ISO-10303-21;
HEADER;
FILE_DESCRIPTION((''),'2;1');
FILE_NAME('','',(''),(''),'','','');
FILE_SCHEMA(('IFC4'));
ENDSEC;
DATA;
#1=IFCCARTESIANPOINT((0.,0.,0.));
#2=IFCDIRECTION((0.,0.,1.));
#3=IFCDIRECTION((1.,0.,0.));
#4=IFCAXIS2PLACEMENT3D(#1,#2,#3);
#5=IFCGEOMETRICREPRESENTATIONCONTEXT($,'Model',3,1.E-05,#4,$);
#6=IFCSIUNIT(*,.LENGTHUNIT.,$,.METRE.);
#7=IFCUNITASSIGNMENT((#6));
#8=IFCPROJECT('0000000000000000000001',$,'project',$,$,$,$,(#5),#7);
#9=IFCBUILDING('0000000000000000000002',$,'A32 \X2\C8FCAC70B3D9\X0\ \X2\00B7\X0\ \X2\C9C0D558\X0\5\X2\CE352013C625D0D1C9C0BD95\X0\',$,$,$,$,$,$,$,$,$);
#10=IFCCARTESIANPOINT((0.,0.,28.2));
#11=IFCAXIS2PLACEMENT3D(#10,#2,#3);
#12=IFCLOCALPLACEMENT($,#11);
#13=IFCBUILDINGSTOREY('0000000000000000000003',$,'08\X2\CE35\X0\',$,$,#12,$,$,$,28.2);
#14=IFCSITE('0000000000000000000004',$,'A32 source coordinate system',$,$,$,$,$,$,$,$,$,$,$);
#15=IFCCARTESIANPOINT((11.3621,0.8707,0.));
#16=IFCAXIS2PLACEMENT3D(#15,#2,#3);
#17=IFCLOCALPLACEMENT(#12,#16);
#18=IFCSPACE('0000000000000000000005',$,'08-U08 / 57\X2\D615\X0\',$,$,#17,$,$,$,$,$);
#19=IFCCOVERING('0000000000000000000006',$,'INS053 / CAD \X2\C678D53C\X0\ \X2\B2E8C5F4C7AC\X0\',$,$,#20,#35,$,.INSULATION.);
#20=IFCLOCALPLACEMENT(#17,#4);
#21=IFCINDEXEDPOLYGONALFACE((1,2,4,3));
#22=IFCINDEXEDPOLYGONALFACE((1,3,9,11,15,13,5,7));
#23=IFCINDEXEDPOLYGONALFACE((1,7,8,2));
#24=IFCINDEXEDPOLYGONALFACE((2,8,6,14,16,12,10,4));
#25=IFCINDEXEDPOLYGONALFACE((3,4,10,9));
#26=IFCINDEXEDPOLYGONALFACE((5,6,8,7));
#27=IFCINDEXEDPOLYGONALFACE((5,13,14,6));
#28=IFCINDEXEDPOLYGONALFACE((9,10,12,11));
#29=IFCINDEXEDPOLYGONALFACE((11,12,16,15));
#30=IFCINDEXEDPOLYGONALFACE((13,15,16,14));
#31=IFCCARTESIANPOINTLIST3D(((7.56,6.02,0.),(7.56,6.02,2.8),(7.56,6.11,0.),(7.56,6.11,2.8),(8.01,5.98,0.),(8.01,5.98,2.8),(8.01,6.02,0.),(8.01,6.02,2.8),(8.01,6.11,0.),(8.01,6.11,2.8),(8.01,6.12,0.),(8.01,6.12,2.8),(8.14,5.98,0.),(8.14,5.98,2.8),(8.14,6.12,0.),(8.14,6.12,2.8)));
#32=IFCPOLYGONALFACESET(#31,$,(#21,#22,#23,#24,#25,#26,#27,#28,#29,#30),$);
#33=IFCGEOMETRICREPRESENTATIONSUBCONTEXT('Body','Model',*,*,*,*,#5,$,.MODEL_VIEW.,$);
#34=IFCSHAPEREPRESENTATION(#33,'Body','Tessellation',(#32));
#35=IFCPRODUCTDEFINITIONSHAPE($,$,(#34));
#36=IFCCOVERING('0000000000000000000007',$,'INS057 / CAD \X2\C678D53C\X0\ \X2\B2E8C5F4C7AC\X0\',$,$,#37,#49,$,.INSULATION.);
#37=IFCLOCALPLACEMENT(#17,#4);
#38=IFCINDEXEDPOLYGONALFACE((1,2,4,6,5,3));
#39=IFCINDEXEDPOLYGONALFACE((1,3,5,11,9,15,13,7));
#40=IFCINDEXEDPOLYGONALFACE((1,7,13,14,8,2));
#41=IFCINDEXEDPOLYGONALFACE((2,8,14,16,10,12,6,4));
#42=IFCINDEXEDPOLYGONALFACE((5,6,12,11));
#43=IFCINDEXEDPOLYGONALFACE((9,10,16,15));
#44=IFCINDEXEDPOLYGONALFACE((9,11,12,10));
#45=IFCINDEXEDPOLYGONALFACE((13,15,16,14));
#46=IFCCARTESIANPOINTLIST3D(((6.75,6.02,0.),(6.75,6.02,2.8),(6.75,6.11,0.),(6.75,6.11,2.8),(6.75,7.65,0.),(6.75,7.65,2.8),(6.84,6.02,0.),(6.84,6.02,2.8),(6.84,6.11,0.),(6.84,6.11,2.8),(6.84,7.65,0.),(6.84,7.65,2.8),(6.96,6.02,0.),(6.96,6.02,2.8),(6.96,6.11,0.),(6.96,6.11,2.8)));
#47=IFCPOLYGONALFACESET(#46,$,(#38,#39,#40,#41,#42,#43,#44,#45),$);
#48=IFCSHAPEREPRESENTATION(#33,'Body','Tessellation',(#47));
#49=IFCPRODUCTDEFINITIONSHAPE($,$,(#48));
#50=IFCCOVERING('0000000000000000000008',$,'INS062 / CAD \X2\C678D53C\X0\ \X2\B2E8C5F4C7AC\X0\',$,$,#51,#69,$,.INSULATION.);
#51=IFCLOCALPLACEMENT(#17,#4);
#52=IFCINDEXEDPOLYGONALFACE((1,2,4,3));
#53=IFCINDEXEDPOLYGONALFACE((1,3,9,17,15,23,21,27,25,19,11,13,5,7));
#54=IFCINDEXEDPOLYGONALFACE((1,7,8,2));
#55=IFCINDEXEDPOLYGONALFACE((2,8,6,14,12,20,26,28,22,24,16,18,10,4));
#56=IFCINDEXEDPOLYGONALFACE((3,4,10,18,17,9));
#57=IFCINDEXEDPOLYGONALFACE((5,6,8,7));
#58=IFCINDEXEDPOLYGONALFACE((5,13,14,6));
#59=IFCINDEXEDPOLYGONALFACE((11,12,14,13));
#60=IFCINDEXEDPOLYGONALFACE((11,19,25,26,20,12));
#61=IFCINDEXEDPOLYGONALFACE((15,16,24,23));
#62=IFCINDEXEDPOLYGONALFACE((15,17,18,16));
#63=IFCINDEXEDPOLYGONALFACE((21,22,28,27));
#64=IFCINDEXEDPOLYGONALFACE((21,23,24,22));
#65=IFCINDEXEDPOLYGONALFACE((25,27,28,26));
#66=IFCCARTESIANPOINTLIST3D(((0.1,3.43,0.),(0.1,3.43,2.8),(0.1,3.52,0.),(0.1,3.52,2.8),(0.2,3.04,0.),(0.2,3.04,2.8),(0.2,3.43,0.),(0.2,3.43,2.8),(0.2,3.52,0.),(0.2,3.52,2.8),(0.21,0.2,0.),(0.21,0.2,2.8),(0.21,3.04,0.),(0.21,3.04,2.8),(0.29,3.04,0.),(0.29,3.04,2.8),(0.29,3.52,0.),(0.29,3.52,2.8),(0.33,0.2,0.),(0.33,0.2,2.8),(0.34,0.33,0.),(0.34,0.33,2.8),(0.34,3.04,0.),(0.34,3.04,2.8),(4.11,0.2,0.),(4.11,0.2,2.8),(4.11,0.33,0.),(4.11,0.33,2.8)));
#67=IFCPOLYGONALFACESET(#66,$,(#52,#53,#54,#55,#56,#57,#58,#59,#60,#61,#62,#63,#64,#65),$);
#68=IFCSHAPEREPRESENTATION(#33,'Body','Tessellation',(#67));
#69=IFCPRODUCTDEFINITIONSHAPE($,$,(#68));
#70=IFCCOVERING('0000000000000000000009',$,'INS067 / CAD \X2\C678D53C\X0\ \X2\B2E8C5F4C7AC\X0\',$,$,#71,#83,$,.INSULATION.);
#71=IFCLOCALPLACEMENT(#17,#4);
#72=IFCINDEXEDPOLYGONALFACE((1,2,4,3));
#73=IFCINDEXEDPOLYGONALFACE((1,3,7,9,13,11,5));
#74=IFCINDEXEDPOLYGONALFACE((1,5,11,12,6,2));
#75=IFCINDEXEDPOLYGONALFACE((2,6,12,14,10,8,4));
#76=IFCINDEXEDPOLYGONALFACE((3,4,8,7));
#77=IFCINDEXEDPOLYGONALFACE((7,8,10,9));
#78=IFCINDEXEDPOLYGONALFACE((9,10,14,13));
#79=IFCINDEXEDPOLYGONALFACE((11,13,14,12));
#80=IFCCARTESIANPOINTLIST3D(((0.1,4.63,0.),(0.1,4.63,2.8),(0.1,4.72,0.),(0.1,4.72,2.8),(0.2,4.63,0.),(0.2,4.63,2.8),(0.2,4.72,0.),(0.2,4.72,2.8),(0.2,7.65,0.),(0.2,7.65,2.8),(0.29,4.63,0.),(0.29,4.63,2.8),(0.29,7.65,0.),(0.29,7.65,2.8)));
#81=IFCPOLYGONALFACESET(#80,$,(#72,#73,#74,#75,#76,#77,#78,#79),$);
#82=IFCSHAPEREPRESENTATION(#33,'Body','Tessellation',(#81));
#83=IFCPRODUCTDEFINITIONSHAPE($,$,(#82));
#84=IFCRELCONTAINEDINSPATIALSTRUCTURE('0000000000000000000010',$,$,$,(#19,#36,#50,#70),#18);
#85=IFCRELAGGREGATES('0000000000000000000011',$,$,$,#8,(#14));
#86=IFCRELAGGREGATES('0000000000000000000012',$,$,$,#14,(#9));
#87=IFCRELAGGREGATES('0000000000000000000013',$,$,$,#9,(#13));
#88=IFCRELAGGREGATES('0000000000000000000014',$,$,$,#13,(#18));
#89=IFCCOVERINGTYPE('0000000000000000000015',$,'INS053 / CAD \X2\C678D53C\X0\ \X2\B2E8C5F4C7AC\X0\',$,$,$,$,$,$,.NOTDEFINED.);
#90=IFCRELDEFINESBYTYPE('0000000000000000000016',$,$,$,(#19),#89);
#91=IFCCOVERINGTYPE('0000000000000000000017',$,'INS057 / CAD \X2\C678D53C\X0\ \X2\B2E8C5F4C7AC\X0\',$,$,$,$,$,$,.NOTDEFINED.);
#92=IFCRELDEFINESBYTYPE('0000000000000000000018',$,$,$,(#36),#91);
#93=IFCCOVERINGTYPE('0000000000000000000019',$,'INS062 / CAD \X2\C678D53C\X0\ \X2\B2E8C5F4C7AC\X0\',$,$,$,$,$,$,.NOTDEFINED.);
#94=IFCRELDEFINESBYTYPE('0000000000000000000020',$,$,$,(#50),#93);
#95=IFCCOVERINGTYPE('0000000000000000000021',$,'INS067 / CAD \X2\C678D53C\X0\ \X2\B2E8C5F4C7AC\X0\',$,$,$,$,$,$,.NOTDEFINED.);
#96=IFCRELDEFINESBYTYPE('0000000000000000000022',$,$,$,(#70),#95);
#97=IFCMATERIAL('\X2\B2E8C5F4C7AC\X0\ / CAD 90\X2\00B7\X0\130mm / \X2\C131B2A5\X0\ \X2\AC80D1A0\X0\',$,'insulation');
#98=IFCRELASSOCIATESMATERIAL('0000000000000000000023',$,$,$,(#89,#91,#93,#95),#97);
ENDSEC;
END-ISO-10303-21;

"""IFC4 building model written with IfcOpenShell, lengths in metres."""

from ifc_helpers import new_model, si_unit, frame, origin, origin_with_axes, place, context, subcontext, project, spatial, polyline, outline, extrude, source, transform, mapped, material, type_object, type_shapes, element, save


model = new_model("IFC4")

# Units and contexts
model_context = context("Model", 3, precision=1e-05, world=origin_with_axes())
body_context = subcontext(model_context, "Body", "Model", "MODEL_VIEW")
ifc_project = project(units=[si_unit("LENGTHUNIT", "METRE")], contexts=[model_context])

# Site, building, storey, space
site = spatial("IfcSite", under=ifc_project, Name="A32 source coordinate system")
building = spatial("IfcBuilding", under=site, Name="A32 주거동 · 지하5층–옥탑지붕")
storey_placement = place(None, frame((0.0, 0.0, 28.2), z_axis=(0.0, 0.0, 1.0), x_axis=(1.0, 0.0, 0.0)))
storey = spatial("IfcBuildingStorey", under=building, at=storey_placement, Name="08층", Elevation=28.2)
space_1_placement = place(storey_placement, frame((11.3621, 0.8707, 0.0), z_axis=(0.0, 0.0, 1.0), x_axis=(1.0, 0.0, 0.0)))
space_1 = spatial("IfcSpace", under=storey, at=space_1_placement, Name="08-U08 / 57형")

# Coverings
ifc_material = material(Name="단열재 / CAD 90·130mm / 성능 검토", Category="insulation")
covering_type_1 = type_object("IfcCoveringType", Name="INS053 / CAD 외피 단열재", PredefinedType="NOTDEFINED", material=ifc_material)
shared_shape_1 = source(origin(), body_context, "Body", "SweptSolid", [
    extrude(outline(polyline([(8.01, 6.12), (8.14, 6.12), (8.14, 5.98), (8.01, 5.98), (8.01, 6.02), (7.56, 6.02), (7.56, 6.11), (8.01, 6.11), (8.01, 6.12)])), origin(), (0.0, 0.0, 1.0), 2.8),
])
type_shapes(covering_type_1, [shared_shape_1])
covering_1_placement = place(space_1_placement, origin_with_axes())
element("IfcCovering", 1, at=covering_1_placement, inside=space_1, type_object=covering_type_1, Name="INS053 / CAD 외피 단열재", PredefinedType="INSULATION", context=body_context, shape_type="MappedRepresentation", body=[
    mapped(shared_shape_1, transform((0.0, 0.0, 0.0), scale=1.0)),
])
covering_type_2 = type_object("IfcCoveringType", Name="INS057 / CAD 외피 단열재", PredefinedType="NOTDEFINED", material=ifc_material)
shared_shape_2 = source(origin(), body_context, "Body", "SweptSolid", [
    extrude(outline(polyline([(6.84, 6.11), (6.96, 6.11), (6.96, 6.02), (6.84, 6.02), (6.75, 6.02), (6.75, 6.11), (6.75, 7.65), (6.84, 7.65), (6.84, 6.11)])), origin(), (0.0, 0.0, 1.0), 2.8),
])
type_shapes(covering_type_2, [shared_shape_2])
covering_2_placement = place(space_1_placement, origin_with_axes())
element("IfcCovering", 2, at=covering_2_placement, inside=space_1, type_object=covering_type_2, Name="INS057 / CAD 외피 단열재", PredefinedType="INSULATION", context=body_context, shape_type="MappedRepresentation", body=[
    mapped(shared_shape_2, transform((0.0, 0.0, 0.0), scale=1.0)),
])
covering_type_3 = type_object("IfcCoveringType", Name="INS062 / CAD 외피 단열재", PredefinedType="NOTDEFINED", material=ifc_material)
shared_shape_3 = source(origin(), body_context, "Body", "SweptSolid", [
    extrude(outline(polyline([(4.11, 0.2), (0.33, 0.2), (0.21, 0.2), (0.21, 3.04), (0.2, 3.04), (0.2, 3.43), (0.1, 3.43), (0.1, 3.52), (0.2, 3.52), (0.29, 3.52), (0.29, 3.04), (0.34, 3.04), (0.34, 0.33), (4.11, 0.33), (4.11, 0.2)])), origin(), (0.0, 0.0, 1.0), 2.8),
])
type_shapes(covering_type_3, [shared_shape_3])
covering_3_placement = place(space_1_placement, origin_with_axes())
element("IfcCovering", 3, at=covering_3_placement, inside=space_1, type_object=covering_type_3, Name="INS062 / CAD 외피 단열재", PredefinedType="INSULATION", context=body_context, shape_type="MappedRepresentation", body=[
    mapped(shared_shape_3, transform((0.0, 0.0, 0.0), scale=1.0)),
])
covering_type_4 = type_object("IfcCoveringType", Name="INS067 / CAD 외피 단열재", PredefinedType="NOTDEFINED", material=ifc_material)
shared_shape_4 = source(origin(), body_context, "Body", "SweptSolid", [
    extrude(outline(polyline([(0.1, 4.72), (0.2, 4.72), (0.2, 7.65), (0.29, 7.65), (0.29, 4.63), (0.2, 4.63), (0.1, 4.63), (0.1, 4.72)])), origin(), (0.0, 0.0, 1.0), 2.8),
])
type_shapes(covering_type_4, [shared_shape_4])
covering_4_placement = place(space_1_placement, origin_with_axes())
element("IfcCovering", 4, at=covering_4_placement, inside=space_1, type_object=covering_type_4, Name="INS067 / CAD 외피 단열재", PredefinedType="INSULATION", context=body_context, shape_type="MappedRepresentation", body=[
    mapped(shared_shape_4, transform((0.0, 0.0, 0.0), scale=1.0)),
])

save(model, "model.ifc")
